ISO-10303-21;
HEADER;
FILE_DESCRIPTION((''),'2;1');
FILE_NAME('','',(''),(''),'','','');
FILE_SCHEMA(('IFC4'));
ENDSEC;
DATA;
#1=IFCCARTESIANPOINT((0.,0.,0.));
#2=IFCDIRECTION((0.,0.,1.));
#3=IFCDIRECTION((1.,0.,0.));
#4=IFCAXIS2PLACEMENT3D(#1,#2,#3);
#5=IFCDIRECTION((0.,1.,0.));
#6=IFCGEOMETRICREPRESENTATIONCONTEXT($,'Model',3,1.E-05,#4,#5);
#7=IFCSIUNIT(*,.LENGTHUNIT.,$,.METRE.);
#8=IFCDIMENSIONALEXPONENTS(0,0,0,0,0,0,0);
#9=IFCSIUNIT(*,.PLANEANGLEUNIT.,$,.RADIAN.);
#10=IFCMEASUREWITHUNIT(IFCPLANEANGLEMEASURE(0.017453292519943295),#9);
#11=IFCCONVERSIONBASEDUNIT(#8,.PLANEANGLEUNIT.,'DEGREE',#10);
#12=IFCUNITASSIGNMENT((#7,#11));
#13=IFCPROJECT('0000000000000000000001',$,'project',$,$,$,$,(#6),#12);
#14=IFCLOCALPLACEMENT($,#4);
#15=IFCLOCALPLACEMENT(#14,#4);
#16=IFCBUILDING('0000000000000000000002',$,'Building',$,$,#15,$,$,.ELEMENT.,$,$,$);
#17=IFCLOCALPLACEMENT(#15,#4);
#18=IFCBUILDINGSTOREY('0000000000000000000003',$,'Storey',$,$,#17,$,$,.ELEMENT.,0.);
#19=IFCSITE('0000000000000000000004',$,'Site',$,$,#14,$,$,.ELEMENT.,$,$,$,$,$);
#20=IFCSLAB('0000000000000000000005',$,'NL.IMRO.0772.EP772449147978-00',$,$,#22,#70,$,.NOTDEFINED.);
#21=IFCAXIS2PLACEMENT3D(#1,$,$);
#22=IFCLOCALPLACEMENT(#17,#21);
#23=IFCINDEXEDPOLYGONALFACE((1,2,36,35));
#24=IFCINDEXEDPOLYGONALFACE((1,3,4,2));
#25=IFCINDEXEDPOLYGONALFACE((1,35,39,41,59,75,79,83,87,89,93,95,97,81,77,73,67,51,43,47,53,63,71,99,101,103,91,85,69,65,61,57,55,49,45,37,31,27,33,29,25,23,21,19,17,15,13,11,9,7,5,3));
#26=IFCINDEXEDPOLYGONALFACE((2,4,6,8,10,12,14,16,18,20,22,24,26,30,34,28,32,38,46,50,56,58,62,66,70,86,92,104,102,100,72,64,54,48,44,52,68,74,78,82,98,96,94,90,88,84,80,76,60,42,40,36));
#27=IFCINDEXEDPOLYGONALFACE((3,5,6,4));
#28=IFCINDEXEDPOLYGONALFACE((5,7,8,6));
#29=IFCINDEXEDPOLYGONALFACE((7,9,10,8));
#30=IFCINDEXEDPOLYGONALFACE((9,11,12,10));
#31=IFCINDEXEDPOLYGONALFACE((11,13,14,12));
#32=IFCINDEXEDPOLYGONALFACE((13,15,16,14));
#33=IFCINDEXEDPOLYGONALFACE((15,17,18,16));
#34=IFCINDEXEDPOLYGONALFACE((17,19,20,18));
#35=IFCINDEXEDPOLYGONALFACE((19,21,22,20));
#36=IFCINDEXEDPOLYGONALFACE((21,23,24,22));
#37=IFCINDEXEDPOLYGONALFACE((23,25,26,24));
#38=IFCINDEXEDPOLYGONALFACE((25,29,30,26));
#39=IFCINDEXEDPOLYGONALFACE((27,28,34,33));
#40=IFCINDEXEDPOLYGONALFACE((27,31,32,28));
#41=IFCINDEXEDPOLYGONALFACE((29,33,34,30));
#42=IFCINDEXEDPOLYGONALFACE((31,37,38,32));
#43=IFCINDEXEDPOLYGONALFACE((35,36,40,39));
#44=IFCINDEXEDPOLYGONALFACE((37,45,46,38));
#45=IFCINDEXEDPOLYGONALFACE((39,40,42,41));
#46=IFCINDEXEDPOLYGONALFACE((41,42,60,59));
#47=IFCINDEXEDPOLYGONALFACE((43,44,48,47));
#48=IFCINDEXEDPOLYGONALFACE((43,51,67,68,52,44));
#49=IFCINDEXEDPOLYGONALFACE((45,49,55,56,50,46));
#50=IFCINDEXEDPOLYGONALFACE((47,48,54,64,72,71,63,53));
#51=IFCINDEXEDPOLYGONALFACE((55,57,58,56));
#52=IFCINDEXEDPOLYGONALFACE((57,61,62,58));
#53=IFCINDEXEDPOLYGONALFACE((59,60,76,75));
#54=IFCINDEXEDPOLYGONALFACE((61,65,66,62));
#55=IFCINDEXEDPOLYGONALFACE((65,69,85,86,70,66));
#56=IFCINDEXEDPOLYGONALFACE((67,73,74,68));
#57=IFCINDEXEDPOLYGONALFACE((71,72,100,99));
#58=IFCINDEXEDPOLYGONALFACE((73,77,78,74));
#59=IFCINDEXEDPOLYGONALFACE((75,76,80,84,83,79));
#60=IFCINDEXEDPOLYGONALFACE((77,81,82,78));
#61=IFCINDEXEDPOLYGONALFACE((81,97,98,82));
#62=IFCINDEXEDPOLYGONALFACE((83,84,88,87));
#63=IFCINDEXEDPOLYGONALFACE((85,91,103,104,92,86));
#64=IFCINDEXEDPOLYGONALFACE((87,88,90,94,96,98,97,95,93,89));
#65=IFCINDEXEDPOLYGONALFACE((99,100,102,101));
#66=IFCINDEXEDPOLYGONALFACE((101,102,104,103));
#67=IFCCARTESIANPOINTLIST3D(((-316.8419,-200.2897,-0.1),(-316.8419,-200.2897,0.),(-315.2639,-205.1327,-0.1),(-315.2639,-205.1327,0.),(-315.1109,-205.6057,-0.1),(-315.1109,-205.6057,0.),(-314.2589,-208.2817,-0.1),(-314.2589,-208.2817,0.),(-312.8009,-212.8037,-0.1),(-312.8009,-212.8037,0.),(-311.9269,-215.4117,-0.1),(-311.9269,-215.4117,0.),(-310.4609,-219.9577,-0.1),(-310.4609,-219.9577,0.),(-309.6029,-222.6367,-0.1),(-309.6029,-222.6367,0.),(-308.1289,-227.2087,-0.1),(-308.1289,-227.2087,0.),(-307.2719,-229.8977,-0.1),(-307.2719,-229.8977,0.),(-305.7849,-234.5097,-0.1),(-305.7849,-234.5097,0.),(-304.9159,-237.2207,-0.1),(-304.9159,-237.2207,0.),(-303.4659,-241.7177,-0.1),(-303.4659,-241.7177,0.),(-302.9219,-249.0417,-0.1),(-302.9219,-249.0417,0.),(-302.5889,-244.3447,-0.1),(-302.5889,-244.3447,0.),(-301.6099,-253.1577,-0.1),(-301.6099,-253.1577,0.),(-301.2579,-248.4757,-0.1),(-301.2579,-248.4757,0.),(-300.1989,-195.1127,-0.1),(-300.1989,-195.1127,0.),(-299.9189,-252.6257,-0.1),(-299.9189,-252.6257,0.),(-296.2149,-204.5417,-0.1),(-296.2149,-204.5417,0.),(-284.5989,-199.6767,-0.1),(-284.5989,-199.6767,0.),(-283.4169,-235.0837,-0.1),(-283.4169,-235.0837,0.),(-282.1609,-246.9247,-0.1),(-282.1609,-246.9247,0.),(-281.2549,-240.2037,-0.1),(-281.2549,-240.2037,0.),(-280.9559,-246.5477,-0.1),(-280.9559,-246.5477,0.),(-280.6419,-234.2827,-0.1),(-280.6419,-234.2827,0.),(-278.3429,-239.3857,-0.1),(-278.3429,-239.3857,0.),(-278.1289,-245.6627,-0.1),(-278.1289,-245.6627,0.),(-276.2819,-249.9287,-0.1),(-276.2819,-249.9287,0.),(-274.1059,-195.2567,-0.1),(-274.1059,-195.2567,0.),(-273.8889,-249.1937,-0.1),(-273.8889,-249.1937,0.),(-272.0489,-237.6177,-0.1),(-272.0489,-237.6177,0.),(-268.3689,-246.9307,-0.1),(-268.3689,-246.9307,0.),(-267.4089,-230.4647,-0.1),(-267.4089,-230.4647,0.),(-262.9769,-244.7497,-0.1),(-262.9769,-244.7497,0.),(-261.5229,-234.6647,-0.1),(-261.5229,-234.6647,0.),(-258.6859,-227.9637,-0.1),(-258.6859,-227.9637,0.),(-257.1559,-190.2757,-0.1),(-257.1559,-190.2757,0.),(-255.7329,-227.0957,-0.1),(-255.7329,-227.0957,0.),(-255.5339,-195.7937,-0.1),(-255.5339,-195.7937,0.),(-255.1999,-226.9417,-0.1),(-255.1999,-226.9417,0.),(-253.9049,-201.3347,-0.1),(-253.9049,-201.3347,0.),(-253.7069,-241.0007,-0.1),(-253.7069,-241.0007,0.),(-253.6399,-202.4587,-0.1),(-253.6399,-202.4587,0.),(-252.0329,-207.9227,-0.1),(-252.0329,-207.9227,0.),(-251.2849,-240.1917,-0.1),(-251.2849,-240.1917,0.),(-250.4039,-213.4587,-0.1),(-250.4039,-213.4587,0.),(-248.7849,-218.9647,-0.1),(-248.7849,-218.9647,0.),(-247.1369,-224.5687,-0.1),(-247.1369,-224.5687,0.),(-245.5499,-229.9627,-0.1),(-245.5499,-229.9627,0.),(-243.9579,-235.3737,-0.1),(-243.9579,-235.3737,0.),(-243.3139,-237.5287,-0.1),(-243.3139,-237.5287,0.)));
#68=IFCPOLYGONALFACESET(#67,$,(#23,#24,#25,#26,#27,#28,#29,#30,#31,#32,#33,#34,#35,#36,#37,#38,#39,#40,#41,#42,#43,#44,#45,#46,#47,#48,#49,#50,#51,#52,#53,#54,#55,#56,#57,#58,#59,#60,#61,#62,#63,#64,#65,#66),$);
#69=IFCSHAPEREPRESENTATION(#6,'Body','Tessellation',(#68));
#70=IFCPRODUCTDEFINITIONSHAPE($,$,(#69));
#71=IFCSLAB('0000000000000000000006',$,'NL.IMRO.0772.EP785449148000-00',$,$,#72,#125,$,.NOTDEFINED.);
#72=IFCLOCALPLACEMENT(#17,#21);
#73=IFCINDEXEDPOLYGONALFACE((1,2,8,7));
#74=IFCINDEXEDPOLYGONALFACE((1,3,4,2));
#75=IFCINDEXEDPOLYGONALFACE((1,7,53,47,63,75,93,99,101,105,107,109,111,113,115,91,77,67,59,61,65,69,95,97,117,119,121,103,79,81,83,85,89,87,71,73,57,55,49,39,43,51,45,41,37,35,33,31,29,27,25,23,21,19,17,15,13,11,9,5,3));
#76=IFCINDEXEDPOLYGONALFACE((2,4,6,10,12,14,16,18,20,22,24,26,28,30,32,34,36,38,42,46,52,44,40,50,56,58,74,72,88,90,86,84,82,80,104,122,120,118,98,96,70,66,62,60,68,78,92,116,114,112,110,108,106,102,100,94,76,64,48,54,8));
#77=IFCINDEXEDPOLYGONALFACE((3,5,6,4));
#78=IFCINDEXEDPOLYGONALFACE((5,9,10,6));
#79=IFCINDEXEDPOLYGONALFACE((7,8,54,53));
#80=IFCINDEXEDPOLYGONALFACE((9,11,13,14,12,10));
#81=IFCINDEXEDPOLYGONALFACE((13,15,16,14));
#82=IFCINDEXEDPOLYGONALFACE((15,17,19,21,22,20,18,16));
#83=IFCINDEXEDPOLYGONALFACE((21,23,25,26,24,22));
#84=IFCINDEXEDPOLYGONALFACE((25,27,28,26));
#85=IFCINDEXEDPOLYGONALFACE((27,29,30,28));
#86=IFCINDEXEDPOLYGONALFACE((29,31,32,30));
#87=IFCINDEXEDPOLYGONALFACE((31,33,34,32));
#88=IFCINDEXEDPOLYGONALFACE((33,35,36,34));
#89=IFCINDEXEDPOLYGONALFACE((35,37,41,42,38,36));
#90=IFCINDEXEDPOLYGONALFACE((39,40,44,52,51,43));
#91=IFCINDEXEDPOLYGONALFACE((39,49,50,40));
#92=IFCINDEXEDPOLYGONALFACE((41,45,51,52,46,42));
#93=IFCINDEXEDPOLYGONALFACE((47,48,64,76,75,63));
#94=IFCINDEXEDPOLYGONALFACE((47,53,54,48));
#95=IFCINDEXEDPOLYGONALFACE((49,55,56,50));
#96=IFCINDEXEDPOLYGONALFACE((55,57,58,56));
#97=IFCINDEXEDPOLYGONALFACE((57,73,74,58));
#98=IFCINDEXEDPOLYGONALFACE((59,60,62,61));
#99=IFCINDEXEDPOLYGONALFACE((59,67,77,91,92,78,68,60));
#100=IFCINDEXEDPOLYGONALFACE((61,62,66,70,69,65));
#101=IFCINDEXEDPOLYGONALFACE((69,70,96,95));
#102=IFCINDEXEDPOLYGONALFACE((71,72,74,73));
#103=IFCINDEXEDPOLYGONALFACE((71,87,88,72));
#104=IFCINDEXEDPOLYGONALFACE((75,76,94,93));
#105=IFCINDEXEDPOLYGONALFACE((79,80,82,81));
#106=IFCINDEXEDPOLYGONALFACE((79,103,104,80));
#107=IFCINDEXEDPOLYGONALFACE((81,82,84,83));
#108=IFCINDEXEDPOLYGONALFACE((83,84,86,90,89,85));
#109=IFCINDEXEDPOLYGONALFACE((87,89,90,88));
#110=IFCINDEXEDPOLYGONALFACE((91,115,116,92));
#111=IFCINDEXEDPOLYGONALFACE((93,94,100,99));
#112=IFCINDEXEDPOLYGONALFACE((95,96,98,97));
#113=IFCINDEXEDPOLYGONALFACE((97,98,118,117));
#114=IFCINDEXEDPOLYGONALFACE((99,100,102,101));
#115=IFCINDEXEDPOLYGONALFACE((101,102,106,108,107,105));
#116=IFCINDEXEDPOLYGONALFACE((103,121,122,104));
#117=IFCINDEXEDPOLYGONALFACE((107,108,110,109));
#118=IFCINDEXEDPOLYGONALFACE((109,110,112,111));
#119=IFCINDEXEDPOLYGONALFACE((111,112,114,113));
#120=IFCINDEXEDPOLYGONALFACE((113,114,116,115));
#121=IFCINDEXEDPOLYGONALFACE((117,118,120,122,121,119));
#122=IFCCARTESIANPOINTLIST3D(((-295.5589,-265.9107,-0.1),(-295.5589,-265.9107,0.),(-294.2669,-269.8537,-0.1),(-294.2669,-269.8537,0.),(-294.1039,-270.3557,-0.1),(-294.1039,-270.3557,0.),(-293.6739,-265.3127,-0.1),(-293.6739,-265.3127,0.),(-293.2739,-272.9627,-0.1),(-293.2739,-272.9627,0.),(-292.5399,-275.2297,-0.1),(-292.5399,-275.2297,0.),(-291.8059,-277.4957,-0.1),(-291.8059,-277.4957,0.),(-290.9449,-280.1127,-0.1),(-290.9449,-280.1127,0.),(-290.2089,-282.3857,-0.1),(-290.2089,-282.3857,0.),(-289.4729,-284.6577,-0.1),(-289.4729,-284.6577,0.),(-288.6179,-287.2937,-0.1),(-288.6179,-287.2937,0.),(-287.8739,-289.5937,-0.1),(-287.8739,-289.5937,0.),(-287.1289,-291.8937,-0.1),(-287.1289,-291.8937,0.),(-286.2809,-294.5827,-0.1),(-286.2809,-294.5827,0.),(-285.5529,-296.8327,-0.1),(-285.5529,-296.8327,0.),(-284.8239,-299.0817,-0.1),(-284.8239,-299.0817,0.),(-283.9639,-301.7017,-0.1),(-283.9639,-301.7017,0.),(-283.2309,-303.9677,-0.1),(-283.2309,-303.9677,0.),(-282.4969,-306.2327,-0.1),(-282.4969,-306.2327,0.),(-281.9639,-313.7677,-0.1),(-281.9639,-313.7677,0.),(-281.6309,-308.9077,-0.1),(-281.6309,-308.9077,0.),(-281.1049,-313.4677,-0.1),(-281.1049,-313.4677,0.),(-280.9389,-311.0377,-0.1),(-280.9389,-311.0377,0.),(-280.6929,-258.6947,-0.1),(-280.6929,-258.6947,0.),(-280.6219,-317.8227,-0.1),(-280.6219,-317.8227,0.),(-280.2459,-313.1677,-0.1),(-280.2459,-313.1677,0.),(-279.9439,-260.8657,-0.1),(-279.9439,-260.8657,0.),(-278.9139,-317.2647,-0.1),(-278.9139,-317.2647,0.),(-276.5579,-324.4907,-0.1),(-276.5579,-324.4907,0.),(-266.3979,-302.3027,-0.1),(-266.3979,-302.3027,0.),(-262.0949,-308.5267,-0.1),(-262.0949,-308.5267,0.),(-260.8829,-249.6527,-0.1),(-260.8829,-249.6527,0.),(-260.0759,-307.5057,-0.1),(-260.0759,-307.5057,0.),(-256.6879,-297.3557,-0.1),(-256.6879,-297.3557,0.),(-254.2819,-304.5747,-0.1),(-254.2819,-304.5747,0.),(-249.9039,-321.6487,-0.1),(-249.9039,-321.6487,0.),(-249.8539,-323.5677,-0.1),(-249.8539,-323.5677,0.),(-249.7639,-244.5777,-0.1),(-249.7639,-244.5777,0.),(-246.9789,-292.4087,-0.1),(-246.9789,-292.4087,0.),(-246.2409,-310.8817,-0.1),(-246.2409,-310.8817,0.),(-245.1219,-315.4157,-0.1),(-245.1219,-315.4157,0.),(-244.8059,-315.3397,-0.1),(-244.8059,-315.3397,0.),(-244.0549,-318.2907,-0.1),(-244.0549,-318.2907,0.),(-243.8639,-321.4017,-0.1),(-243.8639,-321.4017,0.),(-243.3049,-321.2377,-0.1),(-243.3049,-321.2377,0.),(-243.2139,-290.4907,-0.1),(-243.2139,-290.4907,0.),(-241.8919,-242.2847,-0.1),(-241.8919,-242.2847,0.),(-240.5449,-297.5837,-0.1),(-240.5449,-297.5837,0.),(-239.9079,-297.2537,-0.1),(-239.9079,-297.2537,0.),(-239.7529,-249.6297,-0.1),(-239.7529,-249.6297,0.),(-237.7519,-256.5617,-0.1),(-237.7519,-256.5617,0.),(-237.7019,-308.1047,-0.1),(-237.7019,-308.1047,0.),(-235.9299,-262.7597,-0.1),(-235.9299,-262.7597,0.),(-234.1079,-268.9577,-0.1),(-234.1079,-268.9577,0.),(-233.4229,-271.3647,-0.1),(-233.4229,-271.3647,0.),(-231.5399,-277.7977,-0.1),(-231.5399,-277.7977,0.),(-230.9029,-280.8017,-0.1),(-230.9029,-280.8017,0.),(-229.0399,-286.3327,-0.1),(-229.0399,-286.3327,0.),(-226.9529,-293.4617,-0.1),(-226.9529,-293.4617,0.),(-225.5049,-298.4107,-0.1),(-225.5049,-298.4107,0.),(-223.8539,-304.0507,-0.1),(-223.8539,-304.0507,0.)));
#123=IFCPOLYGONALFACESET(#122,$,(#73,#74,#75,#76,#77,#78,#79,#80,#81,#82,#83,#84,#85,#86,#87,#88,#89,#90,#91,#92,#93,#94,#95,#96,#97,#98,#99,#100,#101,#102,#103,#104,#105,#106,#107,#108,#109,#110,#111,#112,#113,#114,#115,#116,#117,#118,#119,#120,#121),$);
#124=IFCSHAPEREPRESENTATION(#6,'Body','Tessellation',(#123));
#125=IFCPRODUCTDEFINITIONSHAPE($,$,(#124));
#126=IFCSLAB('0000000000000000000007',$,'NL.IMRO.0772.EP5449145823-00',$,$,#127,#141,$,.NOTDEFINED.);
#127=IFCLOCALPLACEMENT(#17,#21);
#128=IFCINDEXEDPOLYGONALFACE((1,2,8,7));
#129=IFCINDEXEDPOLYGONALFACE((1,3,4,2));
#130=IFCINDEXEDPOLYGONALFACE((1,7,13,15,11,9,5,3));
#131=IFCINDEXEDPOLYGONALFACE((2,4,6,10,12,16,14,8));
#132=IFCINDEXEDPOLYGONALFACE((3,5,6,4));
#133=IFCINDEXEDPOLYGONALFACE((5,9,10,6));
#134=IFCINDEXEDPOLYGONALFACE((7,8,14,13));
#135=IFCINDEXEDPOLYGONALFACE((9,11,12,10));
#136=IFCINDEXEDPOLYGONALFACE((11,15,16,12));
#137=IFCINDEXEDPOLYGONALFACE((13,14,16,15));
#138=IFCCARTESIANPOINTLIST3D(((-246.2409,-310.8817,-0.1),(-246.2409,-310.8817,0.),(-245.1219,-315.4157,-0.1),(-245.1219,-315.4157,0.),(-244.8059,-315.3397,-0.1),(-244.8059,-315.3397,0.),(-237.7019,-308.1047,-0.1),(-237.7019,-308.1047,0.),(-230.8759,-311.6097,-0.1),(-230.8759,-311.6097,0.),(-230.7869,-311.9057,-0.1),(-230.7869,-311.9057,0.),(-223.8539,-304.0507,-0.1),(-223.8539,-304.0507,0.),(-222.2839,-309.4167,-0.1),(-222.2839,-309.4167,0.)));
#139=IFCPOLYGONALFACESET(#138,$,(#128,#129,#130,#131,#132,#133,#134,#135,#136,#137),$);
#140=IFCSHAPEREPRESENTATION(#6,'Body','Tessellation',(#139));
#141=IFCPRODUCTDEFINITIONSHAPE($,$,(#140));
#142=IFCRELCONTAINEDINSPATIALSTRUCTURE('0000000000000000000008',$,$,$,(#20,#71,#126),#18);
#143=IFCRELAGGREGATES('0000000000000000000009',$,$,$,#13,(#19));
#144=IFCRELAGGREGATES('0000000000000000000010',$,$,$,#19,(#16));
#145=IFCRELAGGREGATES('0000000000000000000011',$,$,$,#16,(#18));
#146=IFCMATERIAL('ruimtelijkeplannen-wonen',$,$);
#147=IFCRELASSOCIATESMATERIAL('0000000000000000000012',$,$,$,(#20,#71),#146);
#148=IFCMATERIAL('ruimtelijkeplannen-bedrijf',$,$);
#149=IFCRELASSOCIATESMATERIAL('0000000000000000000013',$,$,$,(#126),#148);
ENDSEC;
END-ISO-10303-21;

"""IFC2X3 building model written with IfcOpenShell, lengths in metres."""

from ifc_helpers import new_model, entity, si_unit, converted_unit, direction, frame, origin_with_axes, place, context, project, spatial, polyline, outline, extrude, material, element, save


model = new_model("IFC2X3")

# Units and contexts
model_context = context("Model", 3, precision=1e-05, world=origin_with_axes(), true_north=direction((0.0, 1.0, 0.0)))
ifc_project = project(units=[si_unit("LENGTHUNIT", "METRE"), converted_unit("PLANEANGLEUNIT", "DEGREE", entity("IfcPlaneAngleMeasure", 0.017453292519943295), si_unit("PLANEANGLEUNIT", "RADIAN"), dimensions=[0, 0, 0, 0, 0, 0, 0])], contexts=[model_context])

# Site, building, storey
site_placement = place(None, origin_with_axes())
site = spatial("IfcSite", under=ifc_project, at=site_placement, Name="Site", CompositionType="ELEMENT")
building_placement = place(site_placement, origin_with_axes())
building = spatial("IfcBuilding", under=site, at=building_placement, Name="Building", CompositionType="ELEMENT")
storey_placement = place(building_placement, origin_with_axes())
storey = spatial("IfcBuildingStorey", under=building, at=storey_placement, Name="Storey", CompositionType="ELEMENT", Elevation=0.0)

# Slabs
ifc_material_1 = material(Name="ruimtelijkeplannen-wonen")
ifc_material_2 = material(Name="ruimtelijkeplannen-bedrijf")
slab_1_placement = place(storey_placement, frame((0.0, 0.0, -0.1), z_axis=(0.0, 0.0, 1.0), x_axis=(1.0, 0.0, 0.0)))
element("IfcSlab", 1, at=slab_1_placement, inside=storey, material=ifc_material_1, Name="NL.IMRO.0772.EP772449147978-00", PredefinedType="NOTDEFINED", context=model_context, shape_type="SweptSolid", body=[
    extrude(outline(polyline([(-255.5339, -195.7937), (-253.9049, -201.3347), (-253.6399, -202.4587), (-252.0329, -207.9227), (-250.4039, -213.4587), (-248.7849, -218.9647), (-247.1369, -224.5687), (-255.1999, -226.9417), (-255.7329, -227.0957), (-258.6859, -227.9637), (-267.4089, -230.4647), (-280.6419, -234.2827), (-283.4169, -235.0837), (-281.2549, -240.2037), (-278.3429, -239.3857), (-272.0489, -237.6177), (-261.5229, -234.6647), (-245.5499, -229.9627), (-243.9579, -235.3737), (-243.3139, -237.5287), (-251.2849, -240.1917), (-253.7069, -241.0007), (-262.9769, -244.7497), (-268.3689, -246.9307), (-273.8889, -249.1937), (-276.2819, -249.9287), (-278.1289, -245.6627), (-280.9559, -246.5477), (-282.1609, -246.9247), (-299.9189, -252.6257), (-301.6099, -253.1577), (-302.9219, -249.0417), (-301.2579, -248.4757), (-302.5889, -244.3447), (-303.4659, -241.7177), (-304.9159, -237.2207), (-305.7849, -234.5097), (-307.2719, -229.8977), (-308.1289, -227.2087), (-309.6029, -222.6367), (-310.4609, -219.9577), (-311.9269, -215.4117), (-312.8009, -212.8037), (-314.2589, -208.2817), (-315.1109, -205.6057), (-315.2639, -205.1327), (-316.8419, -200.2897), (-300.1989, -195.1127), (-296.2149, -204.5417), (-284.5989, -199.6767), (-274.1059, -195.2567), (-257.1559, -190.2757), (-255.5339, -195.7937)])), origin_with_axes(), (0.0, 0.0, 1.0), 0.1),
])
slab_2_placement = place(storey_placement, frame((0.0, 0.0, -0.1), z_axis=(0.0, 0.0, 1.0), x_axis=(1.0, 0.0, 0.0)))
element("IfcSlab", 2, at=slab_2_placement, inside=storey, material=ifc_material_1, Name="NL.IMRO.0772.EP785449148000-00", PredefinedType="NOTDEFINED", context=model_context, shape_type="SweptSolid", body=[
    extrude(outline(polyline([(-262.0949, -308.5267), (-260.0759, -307.5057), (-254.2819, -304.5747), (-240.5449, -297.5837), (-239.9079, -297.2537), (-226.9529, -293.4617), (-225.5049, -298.4107), (-223.8539, -304.0507), (-237.7019, -308.1047), (-246.2409, -310.8817), (-245.1219, -315.4157), (-244.8059, -315.3397), (-244.0549, -318.2907), (-243.3049, -321.2377), (-243.8639, -321.4017), (-249.9039, -321.6487), (-249.8539, -323.5677), (-276.5579, -324.4907), (-278.9139, -317.2647), (-280.6219, -317.8227), (-281.9639, -313.7677), (-281.1049, -313.4677), (-280.2459, -313.1677), (-280.9389, -311.0377), (-281.6309, -308.9077), (-282.4969, -306.2327), (-283.2309, -303.9677), (-283.9639, -301.7017), (-284.8239, -299.0817), (-285.5529, -296.8327), (-286.2809, -294.5827), (-287.1289, -291.8937), (-287.8739, -289.5937), (-288.6179, -287.2937), (-289.4729, -284.6577), (-290.2089, -282.3857), (-290.9449, -280.1127), (-291.8059, -277.4957), (-292.5399, -275.2297), (-293.2739, -272.9627), (-294.1039, -270.3557), (-294.2669, -269.8537), (-295.5589, -265.9107), (-293.6739, -265.3127), (-279.9439, -260.8657), (-280.6929, -258.6947), (-260.8829, -249.6527), (-249.7639, -244.5777), (-241.8919, -242.2847), (-239.7529, -249.6297), (-237.7519, -256.5617), (-235.9299, -262.7597), (-234.1079, -268.9577), (-233.4229, -271.3647), (-231.5399, -277.7977), (-230.9029, -280.8017), (-229.0399, -286.3327), (-243.2139, -290.4907), (-246.9789, -292.4087), (-256.6879, -297.3557), (-266.3979, -302.3027), (-262.0949, -308.5267)])), origin_with_axes(), (0.0, 0.0, 1.0), 0.1),
])
slab_3_placement = place(storey_placement, frame((0.0, 0.0, -0.1), z_axis=(0.0, 0.0, 1.0), x_axis=(1.0, 0.0, 0.0)))
element("IfcSlab", 3, at=slab_3_placement, inside=storey, material=ifc_material_2, Name="NL.IMRO.0772.EP5449145823-00", PredefinedType="NOTDEFINED", context=model_context, shape_type="SweptSolid", body=[
    extrude(outline(polyline([(-244.8059, -315.3397), (-245.1219, -315.4157), (-246.2409, -310.8817), (-237.7019, -308.1047), (-223.8539, -304.0507), (-222.2839, -309.4167), (-230.7869, -311.9057), (-230.8759, -311.6097), (-244.8059, -315.3397)])), origin_with_axes(), (0.0, 0.0, 1.0), 0.1),
])

save(model, "model.ifc")
